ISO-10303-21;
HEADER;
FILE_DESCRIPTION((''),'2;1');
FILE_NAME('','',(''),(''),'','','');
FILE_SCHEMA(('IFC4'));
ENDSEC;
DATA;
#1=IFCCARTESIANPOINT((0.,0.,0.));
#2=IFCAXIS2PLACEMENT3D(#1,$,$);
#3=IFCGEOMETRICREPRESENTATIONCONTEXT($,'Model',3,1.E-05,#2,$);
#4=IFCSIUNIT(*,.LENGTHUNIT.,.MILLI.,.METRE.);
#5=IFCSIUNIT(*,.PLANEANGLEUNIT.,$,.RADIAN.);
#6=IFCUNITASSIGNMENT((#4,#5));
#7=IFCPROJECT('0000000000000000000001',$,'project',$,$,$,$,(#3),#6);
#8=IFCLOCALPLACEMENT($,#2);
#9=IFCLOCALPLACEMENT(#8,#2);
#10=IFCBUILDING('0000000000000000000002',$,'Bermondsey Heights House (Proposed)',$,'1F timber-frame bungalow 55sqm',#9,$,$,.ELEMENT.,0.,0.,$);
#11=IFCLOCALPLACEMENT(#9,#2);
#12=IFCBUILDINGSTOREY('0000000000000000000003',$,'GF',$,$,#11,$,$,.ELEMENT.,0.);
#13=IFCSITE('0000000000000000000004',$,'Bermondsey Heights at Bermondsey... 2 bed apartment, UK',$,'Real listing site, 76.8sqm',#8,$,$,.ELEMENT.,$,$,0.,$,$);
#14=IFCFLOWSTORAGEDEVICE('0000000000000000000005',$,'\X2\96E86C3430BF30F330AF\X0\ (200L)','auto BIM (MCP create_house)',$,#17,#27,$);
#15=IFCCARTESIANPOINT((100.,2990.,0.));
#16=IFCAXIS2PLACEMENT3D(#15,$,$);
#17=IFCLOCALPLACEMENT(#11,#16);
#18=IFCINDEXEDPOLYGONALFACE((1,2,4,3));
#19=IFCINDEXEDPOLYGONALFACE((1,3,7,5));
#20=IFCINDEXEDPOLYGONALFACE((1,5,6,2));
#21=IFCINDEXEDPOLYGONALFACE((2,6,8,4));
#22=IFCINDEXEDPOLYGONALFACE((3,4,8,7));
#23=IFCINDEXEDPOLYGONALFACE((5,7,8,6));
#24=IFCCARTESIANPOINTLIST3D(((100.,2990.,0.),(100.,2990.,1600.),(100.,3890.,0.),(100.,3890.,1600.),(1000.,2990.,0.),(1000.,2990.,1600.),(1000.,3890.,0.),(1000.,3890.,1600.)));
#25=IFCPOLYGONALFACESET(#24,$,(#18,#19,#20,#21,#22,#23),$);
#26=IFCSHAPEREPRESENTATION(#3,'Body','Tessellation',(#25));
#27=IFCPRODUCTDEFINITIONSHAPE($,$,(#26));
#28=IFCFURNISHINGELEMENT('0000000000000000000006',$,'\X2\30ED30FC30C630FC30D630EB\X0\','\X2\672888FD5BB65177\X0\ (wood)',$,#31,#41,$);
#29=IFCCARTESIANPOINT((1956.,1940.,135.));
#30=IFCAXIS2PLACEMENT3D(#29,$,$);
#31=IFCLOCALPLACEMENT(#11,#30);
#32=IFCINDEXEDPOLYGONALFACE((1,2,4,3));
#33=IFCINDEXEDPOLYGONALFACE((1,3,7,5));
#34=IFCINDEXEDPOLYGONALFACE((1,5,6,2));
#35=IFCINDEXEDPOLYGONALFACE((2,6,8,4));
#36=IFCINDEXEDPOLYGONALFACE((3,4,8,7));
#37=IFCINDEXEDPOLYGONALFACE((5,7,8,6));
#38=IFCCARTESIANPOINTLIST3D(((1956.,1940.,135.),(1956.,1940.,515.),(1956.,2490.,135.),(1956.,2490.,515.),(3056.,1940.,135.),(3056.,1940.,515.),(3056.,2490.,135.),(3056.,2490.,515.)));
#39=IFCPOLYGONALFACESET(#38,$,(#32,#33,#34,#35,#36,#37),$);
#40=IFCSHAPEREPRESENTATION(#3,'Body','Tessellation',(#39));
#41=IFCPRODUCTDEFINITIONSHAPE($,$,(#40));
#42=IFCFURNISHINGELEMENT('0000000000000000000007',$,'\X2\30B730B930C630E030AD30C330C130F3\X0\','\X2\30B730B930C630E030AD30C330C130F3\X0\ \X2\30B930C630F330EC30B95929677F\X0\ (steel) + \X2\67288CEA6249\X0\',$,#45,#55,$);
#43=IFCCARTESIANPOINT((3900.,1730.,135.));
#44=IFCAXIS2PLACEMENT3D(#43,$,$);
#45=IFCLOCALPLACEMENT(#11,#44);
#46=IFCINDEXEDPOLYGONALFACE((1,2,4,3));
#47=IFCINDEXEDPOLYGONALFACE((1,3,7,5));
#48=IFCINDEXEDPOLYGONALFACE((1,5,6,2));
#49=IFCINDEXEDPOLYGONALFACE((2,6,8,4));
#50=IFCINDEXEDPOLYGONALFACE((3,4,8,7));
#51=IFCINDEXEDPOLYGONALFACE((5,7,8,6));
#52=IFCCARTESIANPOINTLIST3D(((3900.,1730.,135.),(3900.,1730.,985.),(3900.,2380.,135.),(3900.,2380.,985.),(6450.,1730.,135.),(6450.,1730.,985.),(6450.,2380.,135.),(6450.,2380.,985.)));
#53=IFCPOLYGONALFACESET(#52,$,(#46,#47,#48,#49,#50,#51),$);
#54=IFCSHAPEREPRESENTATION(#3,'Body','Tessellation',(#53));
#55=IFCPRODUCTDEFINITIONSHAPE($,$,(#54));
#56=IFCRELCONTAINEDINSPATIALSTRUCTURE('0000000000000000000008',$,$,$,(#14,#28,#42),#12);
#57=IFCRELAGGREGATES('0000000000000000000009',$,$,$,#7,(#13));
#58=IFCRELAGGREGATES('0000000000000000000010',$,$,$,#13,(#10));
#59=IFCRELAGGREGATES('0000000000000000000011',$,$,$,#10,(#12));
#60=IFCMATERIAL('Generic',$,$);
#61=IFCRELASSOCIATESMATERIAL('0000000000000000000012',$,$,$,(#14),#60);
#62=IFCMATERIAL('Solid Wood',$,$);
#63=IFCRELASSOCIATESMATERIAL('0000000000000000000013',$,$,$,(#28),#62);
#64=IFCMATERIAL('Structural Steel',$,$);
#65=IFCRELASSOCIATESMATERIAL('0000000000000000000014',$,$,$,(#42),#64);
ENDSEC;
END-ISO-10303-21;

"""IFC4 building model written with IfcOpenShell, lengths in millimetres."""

from ifc_helpers import new_model, si_unit, frame, frame_2d, origin, place, context, project, spatial, rectangle, extrude, material, element, save


model = new_model("IFC4")

# Units and contexts
model_context = context("Model", 3, precision=1e-05, world=origin())
ifc_project = project(units=[si_unit("LENGTHUNIT", "METRE", prefix="MILLI"), si_unit("PLANEANGLEUNIT", "RADIAN")], contexts=[model_context])

# Site, building, storey
site_placement = place(None, origin())
site = spatial("IfcSite", under=ifc_project, at=site_placement, Name="Bermondsey Heights at Bermondsey... 2 bed apartment, UK", ObjectType="Real listing site, 76.8sqm", CompositionType="ELEMENT", RefElevation=0.0)
building_placement = place(site_placement, origin())
building = spatial("IfcBuilding", under=site, at=building_placement, Name="Bermondsey Heights House (Proposed)", ObjectType="1F timber-frame bungalow 55sqm", CompositionType="ELEMENT", ElevationOfRefHeight=0.0, ElevationOfTerrain=0.0)
storey_placement = place(building_placement, origin())
storey = spatial("IfcBuildingStorey", under=building, at=storey_placement, Name="GF", CompositionType="ELEMENT", Elevation=0.0)

# Shared definitions
ifc_material_1 = material(Name="Solid Wood")

# Shared definitions
ifc_material_2 = material(Name="Generic")

# Flow storage device
flow_storage_device_placement = place(storey_placement, frame((100.0, 2990.0, 0.0)))
element("IfcFlowStorageDevice", 1, at=flow_storage_device_placement, inside=storey, material=ifc_material_2, Name="雨水タンク (200L)", Description="auto BIM (MCP create_house)", context=model_context, shape_type="SweptSolid", body=[
    extrude(rectangle(XDim=900.0, YDim=900.0, at=frame_2d((450.0, 450.0))), frame((100.0, 2990.0, 0.0)), (0.0, 0.0, 1.0), 1600.0),
])

# Furnishing elements
furnishing_1_placement = place(storey_placement, frame((1956.0, 1940.0, 135.0)))
element("IfcFurnishingElement", 2, at=furnishing_1_placement, inside=storey, material=ifc_material_1, Name="ローテーブル", Description="木製家具 (wood)", context=model_context, shape_type="SweptSolid", body=[
    extrude(rectangle(XDim=1100.0, YDim=550.0, at=frame_2d((550.0, 275.0))), frame((1956.0, 1940.0, 135.0)), (0.0, 0.0, 1.0), 380.0),
])
ifc_material_3 = material(Name="Structural Steel")
furnishing_2_placement = place(storey_placement, frame((3900.0, 1730.0, 135.0)))
element("IfcFurnishingElement", 3, at=furnishing_2_placement, inside=storey, material=ifc_material_3, Name="システムキッチン", Description="システムキッチン ステンレス天板 (steel) + 木質扉", context=model_context, shape_type="SweptSolid", body=[
    extrude(rectangle(XDim=2550.0, YDim=650.0, at=frame_2d((1275.0, 325.0))), frame((3900.0, 1730.0, 135.0)), (0.0, 0.0, 1.0), 850.0),
])

save(model, "model.ifc")
